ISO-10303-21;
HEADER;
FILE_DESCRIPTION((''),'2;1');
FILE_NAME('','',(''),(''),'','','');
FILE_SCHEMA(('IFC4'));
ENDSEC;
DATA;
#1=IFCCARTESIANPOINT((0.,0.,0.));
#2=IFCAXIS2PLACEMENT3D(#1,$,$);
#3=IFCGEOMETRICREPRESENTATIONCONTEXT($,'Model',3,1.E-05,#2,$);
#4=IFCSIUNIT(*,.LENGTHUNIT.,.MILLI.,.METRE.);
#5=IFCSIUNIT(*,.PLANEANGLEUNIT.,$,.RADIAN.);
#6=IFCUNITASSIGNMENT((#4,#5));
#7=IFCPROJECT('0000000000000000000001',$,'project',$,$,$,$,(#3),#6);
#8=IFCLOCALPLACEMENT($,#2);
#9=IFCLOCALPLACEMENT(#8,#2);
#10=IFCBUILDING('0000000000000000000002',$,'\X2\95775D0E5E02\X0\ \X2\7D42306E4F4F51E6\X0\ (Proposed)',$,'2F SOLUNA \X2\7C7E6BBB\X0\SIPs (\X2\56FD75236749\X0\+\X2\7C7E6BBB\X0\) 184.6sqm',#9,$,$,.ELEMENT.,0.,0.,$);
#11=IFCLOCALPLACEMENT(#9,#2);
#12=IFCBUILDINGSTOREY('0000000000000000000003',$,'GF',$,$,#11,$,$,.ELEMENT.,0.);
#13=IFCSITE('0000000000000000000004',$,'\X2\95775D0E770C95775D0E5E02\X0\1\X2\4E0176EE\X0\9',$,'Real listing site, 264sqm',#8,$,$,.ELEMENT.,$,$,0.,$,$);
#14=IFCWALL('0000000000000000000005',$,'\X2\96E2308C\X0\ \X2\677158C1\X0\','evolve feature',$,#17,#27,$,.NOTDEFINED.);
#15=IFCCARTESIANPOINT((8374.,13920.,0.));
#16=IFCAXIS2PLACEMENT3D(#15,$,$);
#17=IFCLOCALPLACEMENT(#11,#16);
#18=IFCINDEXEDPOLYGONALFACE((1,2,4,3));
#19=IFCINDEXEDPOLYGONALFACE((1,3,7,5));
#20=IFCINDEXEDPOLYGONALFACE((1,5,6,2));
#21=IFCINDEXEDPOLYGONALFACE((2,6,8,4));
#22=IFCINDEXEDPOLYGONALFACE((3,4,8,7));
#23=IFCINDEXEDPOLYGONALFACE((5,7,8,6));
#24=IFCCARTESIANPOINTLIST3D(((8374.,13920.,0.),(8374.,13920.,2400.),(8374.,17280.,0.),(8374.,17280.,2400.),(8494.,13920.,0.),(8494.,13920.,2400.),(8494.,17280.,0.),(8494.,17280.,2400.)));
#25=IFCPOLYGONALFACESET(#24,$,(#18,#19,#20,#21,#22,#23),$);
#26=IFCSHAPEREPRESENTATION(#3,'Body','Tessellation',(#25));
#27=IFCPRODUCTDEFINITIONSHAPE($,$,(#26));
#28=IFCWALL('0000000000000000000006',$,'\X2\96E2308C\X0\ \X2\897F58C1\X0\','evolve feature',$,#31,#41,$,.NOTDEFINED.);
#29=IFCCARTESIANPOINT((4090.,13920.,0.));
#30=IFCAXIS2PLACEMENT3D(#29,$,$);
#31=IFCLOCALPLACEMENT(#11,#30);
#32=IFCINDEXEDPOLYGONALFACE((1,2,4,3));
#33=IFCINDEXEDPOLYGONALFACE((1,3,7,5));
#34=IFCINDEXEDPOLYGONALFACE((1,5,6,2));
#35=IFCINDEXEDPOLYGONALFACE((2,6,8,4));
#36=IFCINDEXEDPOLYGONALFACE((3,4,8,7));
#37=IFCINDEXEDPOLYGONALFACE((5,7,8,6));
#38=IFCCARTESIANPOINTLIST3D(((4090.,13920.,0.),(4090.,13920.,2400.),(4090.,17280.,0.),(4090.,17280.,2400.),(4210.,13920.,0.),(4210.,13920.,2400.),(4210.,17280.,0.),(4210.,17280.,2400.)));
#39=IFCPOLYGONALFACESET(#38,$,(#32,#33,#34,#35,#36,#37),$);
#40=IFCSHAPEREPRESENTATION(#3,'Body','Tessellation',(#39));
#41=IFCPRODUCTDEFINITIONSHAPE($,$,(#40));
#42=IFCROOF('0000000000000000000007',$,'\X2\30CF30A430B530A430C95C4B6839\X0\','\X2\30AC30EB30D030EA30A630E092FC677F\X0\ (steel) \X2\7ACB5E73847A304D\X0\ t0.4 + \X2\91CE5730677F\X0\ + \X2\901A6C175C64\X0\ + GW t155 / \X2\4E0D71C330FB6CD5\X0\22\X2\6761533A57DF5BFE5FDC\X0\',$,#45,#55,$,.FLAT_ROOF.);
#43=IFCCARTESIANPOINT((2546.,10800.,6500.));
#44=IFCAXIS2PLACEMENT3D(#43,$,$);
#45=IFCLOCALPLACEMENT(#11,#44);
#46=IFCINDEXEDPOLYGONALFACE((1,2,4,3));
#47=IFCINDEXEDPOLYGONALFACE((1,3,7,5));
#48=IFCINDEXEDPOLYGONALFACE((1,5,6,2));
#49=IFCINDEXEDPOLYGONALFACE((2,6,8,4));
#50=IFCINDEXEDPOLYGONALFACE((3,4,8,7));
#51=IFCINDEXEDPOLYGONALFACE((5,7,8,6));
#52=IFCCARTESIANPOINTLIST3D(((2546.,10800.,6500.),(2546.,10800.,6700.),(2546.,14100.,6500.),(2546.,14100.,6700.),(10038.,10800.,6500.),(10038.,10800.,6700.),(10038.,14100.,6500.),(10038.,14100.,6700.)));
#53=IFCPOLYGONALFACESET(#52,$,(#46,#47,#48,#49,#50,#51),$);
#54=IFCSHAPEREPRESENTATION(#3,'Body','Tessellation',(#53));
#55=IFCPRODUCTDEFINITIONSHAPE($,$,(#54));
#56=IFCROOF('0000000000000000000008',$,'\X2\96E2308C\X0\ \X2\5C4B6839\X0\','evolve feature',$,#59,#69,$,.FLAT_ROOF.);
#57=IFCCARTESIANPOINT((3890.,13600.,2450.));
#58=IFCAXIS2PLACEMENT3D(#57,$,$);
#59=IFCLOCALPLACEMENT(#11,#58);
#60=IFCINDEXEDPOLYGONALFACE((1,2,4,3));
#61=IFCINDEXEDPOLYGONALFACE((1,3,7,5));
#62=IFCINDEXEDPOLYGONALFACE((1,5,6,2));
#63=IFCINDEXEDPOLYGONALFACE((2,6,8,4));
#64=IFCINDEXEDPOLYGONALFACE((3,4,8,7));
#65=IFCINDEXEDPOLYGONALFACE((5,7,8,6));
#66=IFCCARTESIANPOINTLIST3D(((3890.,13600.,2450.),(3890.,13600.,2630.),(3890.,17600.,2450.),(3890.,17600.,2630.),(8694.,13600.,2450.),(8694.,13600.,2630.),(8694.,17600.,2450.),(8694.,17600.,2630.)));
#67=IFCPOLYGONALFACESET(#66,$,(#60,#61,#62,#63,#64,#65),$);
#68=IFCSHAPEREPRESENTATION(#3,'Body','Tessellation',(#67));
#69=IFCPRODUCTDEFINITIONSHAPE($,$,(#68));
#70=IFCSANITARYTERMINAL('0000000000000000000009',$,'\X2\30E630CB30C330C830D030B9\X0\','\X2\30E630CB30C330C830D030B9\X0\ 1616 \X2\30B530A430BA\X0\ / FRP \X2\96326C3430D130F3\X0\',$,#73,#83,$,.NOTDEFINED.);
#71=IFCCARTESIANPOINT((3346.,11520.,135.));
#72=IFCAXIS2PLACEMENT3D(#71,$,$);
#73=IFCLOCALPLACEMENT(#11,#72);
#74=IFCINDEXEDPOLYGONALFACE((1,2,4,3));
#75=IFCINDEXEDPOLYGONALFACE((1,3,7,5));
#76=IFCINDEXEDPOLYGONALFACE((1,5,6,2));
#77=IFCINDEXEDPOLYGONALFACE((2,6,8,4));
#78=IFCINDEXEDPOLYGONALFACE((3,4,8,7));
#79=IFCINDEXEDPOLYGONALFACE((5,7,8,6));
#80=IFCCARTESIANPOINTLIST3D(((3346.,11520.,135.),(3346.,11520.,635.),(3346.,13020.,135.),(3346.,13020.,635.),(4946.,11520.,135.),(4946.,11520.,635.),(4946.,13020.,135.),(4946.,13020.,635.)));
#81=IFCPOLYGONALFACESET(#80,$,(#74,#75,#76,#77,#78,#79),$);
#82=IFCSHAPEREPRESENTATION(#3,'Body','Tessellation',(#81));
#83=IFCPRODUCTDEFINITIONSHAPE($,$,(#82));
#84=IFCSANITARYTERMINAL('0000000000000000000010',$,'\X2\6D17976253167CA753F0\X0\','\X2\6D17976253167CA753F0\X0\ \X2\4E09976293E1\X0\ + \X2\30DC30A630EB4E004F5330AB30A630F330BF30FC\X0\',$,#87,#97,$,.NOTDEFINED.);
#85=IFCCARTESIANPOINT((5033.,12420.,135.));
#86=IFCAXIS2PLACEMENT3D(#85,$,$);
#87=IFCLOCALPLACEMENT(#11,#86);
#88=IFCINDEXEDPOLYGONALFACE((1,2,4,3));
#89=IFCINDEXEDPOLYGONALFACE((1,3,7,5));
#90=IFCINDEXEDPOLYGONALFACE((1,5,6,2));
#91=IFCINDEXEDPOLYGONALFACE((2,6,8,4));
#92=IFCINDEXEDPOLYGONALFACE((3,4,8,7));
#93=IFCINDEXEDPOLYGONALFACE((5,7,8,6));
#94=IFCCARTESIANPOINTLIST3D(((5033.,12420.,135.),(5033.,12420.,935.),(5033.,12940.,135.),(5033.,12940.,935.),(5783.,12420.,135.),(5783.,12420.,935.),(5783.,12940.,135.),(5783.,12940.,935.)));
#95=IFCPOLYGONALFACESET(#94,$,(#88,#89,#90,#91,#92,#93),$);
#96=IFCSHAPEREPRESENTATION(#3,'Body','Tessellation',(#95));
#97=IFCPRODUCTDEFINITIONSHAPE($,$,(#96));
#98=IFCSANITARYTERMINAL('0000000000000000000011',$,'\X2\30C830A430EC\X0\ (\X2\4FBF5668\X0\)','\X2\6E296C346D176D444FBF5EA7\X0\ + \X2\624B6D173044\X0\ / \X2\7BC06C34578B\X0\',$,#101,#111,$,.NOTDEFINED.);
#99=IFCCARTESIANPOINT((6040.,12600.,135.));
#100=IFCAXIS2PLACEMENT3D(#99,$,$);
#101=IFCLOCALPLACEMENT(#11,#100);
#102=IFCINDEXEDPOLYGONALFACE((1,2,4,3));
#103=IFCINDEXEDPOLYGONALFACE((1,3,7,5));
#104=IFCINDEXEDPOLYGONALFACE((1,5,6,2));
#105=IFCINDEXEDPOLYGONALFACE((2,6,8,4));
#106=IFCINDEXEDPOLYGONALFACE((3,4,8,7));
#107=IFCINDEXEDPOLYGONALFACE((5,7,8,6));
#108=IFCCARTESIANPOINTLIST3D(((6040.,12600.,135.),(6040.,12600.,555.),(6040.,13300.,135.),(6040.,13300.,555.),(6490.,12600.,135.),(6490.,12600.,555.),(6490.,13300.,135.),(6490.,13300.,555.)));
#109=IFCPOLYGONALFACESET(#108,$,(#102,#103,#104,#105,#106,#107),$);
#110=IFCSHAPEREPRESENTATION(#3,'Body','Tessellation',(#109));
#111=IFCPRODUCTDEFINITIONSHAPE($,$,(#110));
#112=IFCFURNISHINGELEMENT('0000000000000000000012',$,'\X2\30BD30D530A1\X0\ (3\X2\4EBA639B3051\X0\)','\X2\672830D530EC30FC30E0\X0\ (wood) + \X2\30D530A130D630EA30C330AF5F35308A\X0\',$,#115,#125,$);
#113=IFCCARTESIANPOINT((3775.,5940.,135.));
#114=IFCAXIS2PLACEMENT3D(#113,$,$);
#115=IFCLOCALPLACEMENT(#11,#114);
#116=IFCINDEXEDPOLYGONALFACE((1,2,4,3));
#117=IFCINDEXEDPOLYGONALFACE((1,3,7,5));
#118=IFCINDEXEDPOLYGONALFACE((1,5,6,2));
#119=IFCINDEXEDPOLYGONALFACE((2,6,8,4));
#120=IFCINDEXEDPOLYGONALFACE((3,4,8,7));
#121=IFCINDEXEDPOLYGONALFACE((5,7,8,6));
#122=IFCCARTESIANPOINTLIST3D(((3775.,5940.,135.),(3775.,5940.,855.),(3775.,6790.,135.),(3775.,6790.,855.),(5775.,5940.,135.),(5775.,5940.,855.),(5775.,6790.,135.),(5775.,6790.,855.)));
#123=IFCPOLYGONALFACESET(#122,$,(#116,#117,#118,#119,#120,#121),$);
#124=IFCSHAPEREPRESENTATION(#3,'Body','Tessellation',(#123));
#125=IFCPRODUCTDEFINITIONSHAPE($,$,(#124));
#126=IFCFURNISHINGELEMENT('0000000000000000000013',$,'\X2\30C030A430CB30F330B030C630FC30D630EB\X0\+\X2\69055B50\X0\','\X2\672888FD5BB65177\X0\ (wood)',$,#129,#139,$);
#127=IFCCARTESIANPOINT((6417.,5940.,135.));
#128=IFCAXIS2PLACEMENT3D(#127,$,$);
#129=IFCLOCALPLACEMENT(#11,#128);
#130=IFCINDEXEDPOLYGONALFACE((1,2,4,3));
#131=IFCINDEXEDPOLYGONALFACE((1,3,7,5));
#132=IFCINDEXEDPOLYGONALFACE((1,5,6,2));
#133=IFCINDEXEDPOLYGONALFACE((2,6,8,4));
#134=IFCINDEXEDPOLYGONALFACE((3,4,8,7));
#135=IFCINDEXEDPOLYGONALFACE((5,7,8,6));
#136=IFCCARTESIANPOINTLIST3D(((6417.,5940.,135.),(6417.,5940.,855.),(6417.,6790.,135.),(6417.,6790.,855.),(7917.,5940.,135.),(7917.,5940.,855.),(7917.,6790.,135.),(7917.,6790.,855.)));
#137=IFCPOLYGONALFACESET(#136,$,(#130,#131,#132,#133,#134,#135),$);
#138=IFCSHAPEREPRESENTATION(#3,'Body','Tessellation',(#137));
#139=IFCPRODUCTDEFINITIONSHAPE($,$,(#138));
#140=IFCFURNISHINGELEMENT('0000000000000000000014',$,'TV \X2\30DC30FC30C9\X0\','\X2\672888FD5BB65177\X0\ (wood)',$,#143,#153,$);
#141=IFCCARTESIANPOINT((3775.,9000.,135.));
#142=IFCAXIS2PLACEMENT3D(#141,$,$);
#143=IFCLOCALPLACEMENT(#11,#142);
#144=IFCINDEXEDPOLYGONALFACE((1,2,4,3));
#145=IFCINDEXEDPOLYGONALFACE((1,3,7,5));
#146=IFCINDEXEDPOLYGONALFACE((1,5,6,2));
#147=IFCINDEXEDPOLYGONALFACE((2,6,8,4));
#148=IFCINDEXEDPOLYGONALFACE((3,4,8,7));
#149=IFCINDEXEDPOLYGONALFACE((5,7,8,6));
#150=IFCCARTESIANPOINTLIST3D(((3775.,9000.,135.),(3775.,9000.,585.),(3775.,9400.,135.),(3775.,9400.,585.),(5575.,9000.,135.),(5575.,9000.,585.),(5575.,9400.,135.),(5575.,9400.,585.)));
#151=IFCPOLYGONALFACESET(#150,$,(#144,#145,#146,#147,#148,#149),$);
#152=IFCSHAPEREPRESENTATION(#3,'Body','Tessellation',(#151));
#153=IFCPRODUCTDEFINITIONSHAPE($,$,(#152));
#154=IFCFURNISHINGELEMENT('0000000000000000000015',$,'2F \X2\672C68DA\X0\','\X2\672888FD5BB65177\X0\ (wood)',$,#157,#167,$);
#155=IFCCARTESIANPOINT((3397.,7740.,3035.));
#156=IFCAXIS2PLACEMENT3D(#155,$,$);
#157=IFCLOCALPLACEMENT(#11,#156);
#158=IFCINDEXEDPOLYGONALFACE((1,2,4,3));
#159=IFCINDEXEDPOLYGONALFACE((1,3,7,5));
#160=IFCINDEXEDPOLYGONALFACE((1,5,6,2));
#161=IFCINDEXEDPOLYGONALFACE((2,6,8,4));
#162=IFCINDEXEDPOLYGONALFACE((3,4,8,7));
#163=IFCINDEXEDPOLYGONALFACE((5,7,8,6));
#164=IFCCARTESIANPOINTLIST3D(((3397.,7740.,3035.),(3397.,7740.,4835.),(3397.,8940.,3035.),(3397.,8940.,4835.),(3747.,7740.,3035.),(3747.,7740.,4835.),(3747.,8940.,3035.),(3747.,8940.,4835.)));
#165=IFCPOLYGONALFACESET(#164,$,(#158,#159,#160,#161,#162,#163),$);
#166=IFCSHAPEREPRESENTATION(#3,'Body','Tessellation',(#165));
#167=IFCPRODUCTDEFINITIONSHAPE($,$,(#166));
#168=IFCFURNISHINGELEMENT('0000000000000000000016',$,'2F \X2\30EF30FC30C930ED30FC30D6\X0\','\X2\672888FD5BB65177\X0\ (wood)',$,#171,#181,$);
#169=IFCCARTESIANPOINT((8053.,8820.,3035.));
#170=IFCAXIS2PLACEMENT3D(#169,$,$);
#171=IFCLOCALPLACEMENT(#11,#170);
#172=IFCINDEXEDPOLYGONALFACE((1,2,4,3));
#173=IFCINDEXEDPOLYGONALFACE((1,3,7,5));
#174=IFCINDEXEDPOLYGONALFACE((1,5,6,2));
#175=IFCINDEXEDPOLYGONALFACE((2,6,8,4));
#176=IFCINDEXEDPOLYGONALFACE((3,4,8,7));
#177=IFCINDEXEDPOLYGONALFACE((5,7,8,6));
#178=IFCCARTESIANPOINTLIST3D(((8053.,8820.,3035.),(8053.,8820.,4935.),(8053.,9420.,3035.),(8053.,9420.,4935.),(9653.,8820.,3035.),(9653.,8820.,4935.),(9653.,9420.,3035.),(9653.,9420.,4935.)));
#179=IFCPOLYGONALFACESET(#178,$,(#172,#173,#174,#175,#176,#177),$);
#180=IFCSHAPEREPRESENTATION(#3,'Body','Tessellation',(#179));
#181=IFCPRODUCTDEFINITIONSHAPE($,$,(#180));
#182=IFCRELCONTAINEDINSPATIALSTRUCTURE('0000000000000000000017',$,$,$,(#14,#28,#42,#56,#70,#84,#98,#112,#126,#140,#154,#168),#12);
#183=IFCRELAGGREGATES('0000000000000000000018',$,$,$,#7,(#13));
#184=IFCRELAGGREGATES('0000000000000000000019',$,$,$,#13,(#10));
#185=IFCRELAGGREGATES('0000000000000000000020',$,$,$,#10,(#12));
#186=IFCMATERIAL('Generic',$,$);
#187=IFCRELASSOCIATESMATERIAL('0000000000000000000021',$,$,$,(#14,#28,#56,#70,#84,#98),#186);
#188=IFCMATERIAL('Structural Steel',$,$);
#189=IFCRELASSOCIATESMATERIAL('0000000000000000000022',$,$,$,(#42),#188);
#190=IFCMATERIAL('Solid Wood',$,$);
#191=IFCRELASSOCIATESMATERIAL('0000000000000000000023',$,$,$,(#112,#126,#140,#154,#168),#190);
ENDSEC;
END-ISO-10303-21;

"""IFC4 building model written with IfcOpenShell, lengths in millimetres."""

from ifc_helpers import new_model, si_unit, frame, frame_2d, origin, place, context, project, spatial, rectangle, extrude, material, element, save


model = new_model("IFC4")

# Units and contexts
model_context = context("Model", 3, precision=1e-05, world=origin())
ifc_project = project(units=[si_unit("LENGTHUNIT", "METRE", prefix="MILLI"), si_unit("PLANEANGLEUNIT", "RADIAN")], contexts=[model_context])

# Site, building, storey
site_placement = place(None, origin())
site = spatial("IfcSite", under=ifc_project, at=site_placement, Name="長崎県長崎市1丁目9", ObjectType="Real listing site, 264sqm", CompositionType="ELEMENT", RefElevation=0.0)
building_placement = place(site_placement, origin())
building = spatial("IfcBuilding", under=site, at=building_placement, Name="長崎市 終の住処 (Proposed)", ObjectType="2F SOLUNA 籾殻SIPs (国産杉+籾殻) 184.6sqm", CompositionType="ELEMENT", ElevationOfRefHeight=0.0, ElevationOfTerrain=0.0)
storey_placement = place(building_placement, origin())
storey = spatial("IfcBuildingStorey", under=building, at=storey_placement, Name="GF", CompositionType="ELEMENT", Elevation=0.0)

# Shared definitions
ifc_material_1 = material(Name="Generic")

# Shared definitions
ifc_material_2 = material(Name="Solid Wood")

# Walls
wall_1_placement = place(storey_placement, frame((8374.0, 13920.0, 0.0)))
element("IfcWall", 1, at=wall_1_placement, inside=storey, material=ifc_material_1, Name="離れ 東壁", Description="evolve feature", PredefinedType="NOTDEFINED", context=model_context, shape_type="SweptSolid", body=[
    extrude(rectangle(XDim=120.0, YDim=3360.0, at=frame_2d((60.0, 1680.0))), frame((8374.0, 13920.0, 0.0)), (0.0, 0.0, 1.0), 2400.0),
])
wall_2_placement = place(storey_placement, frame((4090.0, 13920.0, 0.0)))
element("IfcWall", 2, at=wall_2_placement, inside=storey, material=ifc_material_1, Name="離れ 西壁", Description="evolve feature", PredefinedType="NOTDEFINED", context=model_context, shape_type="SweptSolid", body=[
    extrude(rectangle(XDim=120.0, YDim=3360.0, at=frame_2d((60.0, 1680.0))), frame((4090.0, 13920.0, 0.0)), (0.0, 0.0, 1.0), 2400.0),
])

# Roofs
ifc_material_3 = material(Name="Structural Steel")
roof_1_placement = place(storey_placement, frame((2546.0, 10800.0, 6500.0)))
element("IfcRoof", 3, at=roof_1_placement, inside=storey, material=ifc_material_3, Name="ハイサイド屋根", Description="ガルバリウム鋼板 (steel) 立平葺き t0.4 + 野地板 + 通気層 + GW t155 / 不燃・法22条区域対応", PredefinedType="FLAT_ROOF", context=model_context, shape_type="SweptSolid", body=[
    extrude(rectangle(XDim=7492.0, YDim=3300.0, at=frame_2d((3746.0, 1650.0))), frame((2546.0, 10800.0, 6500.0)), (0.0, 0.0, 1.0), 200.0),
])
roof_2_placement = place(storey_placement, frame((3890.0, 13600.0, 2450.0)))
element("IfcRoof", 4, at=roof_2_placement, inside=storey, material=ifc_material_1, Name="離れ 屋根", Description="evolve feature", PredefinedType="FLAT_ROOF", context=model_context, shape_type="SweptSolid", body=[
    extrude(rectangle(XDim=4804.0, YDim=4000.0, at=frame_2d((2402.0, 2000.0))), frame((3890.0, 13600.0, 2450.0)), (0.0, 0.0, 1.0), 180.0),
])

# Sanitary terminals
sanitary_terminal_1_placement = place(storey_placement, frame((3346.0, 11520.0, 135.0)))
element("IfcSanitaryTerminal", 5, at=sanitary_terminal_1_placement, inside=storey, material=ifc_material_1, Name="ユニットバス", Description="ユニットバス 1616 サイズ / FRP 防水パン", PredefinedType="NOTDEFINED", context=model_context, shape_type="SweptSolid", body=[
    extrude(rectangle(XDim=1600.0, YDim=1500.0, at=frame_2d((800.0, 750.0))), frame((3346.0, 11520.0, 135.0)), (0.0, 0.0, 1.0), 500.0),
])
sanitary_terminal_2_placement = place(storey_placement, frame((5033.0, 12420.0, 135.0)))
element("IfcSanitaryTerminal", 6, at=sanitary_terminal_2_placement, inside=storey, material=ifc_material_1, Name="洗面化粧台", Description="洗面化粧台 三面鏡 + ボウル一体カウンター", PredefinedType="NOTDEFINED", context=model_context, shape_type="SweptSolid", body=[
    extrude(rectangle(XDim=750.0, YDim=520.0, at=frame_2d((375.0, 260.0))), frame((5033.0, 12420.0, 135.0)), (0.0, 0.0, 1.0), 800.0),
])
sanitary_terminal_3_placement = place(storey_placement, frame((6040.0, 12600.0, 135.0)))
element("IfcSanitaryTerminal", 7, at=sanitary_terminal_3_placement, inside=storey, material=ifc_material_1, Name="トイレ (便器)", Description="温水洗浄便座 + 手洗い / 節水型", PredefinedType="NOTDEFINED", context=model_context, shape_type="SweptSolid", body=[
    extrude(rectangle(XDim=450.0, YDim=700.0, at=frame_2d((225.0, 350.0))), frame((6040.0, 12600.0, 135.0)), (0.0, 0.0, 1.0), 420.0),
])

# Furnishing elements
furnishing_1_placement = place(storey_placement, frame((3775.0, 5940.0, 135.0)))
element("IfcFurnishingElement", 8, at=furnishing_1_placement, inside=storey, material=ifc_material_2, Name="ソファ (3人掛け)", Description="木フレーム (wood) + ファブリック張り", context=model_context, shape_type="SweptSolid", body=[
    extrude(rectangle(XDim=2000.0, YDim=850.0, at=frame_2d((1000.0, 425.0))), frame((3775.0, 5940.0, 135.0)), (0.0, 0.0, 1.0), 720.0),
])
furnishing_2_placement = place(storey_placement, frame((6417.0, 5940.0, 135.0)))
element("IfcFurnishingElement", 9, at=furnishing_2_placement, inside=storey, material=ifc_material_2, Name="ダイニングテーブル+椅子", Description="木製家具 (wood)", context=model_context, shape_type="SweptSolid", body=[
    extrude(rectangle(XDim=1500.0, YDim=850.0, at=frame_2d((750.0, 425.0))), frame((6417.0, 5940.0, 135.0)), (0.0, 0.0, 1.0), 720.0),
])
furnishing_3_placement = place(storey_placement, frame((3775.0, 9000.0, 135.0)))
element("IfcFurnishingElement", 10, at=furnishing_3_placement, inside=storey, material=ifc_material_2, Name="TV ボード", Description="木製家具 (wood)", context=model_context, shape_type="SweptSolid", body=[
    extrude(rectangle(XDim=1800.0, YDim=400.0, at=frame_2d((900.0, 200.0))), frame((3775.0, 9000.0, 135.0)), (0.0, 0.0, 1.0), 450.0),
])
furnishing_4_placement = place(storey_placement, frame((3397.0, 7740.0, 3035.0)))
element("IfcFurnishingElement", 11, at=furnishing_4_placement, inside=storey, material=ifc_material_2, Name="2F 本棚", Description="木製家具 (wood)", context=model_context, shape_type="SweptSolid", body=[
    extrude(rectangle(XDim=350.0, YDim=1200.0, at=frame_2d((175.0, 600.0))), frame((3397.0, 7740.0, 3035.0)), (0.0, 0.0, 1.0), 1800.0),
])
furnishing_5_placement = place(storey_placement, frame((8053.0, 8820.0, 3035.0)))
element("IfcFurnishingElement", 12, at=furnishing_5_placement, inside=storey, material=ifc_material_2, Name="2F ワードローブ", Description="木製家具 (wood)", context=model_context, shape_type="SweptSolid", body=[
    extrude(rectangle(XDim=1600.0, YDim=600.0, at=frame_2d((800.0, 300.0))), frame((8053.0, 8820.0, 3035.0)), (0.0, 0.0, 1.0), 1900.0),
])

save(model, "model.ifc")
